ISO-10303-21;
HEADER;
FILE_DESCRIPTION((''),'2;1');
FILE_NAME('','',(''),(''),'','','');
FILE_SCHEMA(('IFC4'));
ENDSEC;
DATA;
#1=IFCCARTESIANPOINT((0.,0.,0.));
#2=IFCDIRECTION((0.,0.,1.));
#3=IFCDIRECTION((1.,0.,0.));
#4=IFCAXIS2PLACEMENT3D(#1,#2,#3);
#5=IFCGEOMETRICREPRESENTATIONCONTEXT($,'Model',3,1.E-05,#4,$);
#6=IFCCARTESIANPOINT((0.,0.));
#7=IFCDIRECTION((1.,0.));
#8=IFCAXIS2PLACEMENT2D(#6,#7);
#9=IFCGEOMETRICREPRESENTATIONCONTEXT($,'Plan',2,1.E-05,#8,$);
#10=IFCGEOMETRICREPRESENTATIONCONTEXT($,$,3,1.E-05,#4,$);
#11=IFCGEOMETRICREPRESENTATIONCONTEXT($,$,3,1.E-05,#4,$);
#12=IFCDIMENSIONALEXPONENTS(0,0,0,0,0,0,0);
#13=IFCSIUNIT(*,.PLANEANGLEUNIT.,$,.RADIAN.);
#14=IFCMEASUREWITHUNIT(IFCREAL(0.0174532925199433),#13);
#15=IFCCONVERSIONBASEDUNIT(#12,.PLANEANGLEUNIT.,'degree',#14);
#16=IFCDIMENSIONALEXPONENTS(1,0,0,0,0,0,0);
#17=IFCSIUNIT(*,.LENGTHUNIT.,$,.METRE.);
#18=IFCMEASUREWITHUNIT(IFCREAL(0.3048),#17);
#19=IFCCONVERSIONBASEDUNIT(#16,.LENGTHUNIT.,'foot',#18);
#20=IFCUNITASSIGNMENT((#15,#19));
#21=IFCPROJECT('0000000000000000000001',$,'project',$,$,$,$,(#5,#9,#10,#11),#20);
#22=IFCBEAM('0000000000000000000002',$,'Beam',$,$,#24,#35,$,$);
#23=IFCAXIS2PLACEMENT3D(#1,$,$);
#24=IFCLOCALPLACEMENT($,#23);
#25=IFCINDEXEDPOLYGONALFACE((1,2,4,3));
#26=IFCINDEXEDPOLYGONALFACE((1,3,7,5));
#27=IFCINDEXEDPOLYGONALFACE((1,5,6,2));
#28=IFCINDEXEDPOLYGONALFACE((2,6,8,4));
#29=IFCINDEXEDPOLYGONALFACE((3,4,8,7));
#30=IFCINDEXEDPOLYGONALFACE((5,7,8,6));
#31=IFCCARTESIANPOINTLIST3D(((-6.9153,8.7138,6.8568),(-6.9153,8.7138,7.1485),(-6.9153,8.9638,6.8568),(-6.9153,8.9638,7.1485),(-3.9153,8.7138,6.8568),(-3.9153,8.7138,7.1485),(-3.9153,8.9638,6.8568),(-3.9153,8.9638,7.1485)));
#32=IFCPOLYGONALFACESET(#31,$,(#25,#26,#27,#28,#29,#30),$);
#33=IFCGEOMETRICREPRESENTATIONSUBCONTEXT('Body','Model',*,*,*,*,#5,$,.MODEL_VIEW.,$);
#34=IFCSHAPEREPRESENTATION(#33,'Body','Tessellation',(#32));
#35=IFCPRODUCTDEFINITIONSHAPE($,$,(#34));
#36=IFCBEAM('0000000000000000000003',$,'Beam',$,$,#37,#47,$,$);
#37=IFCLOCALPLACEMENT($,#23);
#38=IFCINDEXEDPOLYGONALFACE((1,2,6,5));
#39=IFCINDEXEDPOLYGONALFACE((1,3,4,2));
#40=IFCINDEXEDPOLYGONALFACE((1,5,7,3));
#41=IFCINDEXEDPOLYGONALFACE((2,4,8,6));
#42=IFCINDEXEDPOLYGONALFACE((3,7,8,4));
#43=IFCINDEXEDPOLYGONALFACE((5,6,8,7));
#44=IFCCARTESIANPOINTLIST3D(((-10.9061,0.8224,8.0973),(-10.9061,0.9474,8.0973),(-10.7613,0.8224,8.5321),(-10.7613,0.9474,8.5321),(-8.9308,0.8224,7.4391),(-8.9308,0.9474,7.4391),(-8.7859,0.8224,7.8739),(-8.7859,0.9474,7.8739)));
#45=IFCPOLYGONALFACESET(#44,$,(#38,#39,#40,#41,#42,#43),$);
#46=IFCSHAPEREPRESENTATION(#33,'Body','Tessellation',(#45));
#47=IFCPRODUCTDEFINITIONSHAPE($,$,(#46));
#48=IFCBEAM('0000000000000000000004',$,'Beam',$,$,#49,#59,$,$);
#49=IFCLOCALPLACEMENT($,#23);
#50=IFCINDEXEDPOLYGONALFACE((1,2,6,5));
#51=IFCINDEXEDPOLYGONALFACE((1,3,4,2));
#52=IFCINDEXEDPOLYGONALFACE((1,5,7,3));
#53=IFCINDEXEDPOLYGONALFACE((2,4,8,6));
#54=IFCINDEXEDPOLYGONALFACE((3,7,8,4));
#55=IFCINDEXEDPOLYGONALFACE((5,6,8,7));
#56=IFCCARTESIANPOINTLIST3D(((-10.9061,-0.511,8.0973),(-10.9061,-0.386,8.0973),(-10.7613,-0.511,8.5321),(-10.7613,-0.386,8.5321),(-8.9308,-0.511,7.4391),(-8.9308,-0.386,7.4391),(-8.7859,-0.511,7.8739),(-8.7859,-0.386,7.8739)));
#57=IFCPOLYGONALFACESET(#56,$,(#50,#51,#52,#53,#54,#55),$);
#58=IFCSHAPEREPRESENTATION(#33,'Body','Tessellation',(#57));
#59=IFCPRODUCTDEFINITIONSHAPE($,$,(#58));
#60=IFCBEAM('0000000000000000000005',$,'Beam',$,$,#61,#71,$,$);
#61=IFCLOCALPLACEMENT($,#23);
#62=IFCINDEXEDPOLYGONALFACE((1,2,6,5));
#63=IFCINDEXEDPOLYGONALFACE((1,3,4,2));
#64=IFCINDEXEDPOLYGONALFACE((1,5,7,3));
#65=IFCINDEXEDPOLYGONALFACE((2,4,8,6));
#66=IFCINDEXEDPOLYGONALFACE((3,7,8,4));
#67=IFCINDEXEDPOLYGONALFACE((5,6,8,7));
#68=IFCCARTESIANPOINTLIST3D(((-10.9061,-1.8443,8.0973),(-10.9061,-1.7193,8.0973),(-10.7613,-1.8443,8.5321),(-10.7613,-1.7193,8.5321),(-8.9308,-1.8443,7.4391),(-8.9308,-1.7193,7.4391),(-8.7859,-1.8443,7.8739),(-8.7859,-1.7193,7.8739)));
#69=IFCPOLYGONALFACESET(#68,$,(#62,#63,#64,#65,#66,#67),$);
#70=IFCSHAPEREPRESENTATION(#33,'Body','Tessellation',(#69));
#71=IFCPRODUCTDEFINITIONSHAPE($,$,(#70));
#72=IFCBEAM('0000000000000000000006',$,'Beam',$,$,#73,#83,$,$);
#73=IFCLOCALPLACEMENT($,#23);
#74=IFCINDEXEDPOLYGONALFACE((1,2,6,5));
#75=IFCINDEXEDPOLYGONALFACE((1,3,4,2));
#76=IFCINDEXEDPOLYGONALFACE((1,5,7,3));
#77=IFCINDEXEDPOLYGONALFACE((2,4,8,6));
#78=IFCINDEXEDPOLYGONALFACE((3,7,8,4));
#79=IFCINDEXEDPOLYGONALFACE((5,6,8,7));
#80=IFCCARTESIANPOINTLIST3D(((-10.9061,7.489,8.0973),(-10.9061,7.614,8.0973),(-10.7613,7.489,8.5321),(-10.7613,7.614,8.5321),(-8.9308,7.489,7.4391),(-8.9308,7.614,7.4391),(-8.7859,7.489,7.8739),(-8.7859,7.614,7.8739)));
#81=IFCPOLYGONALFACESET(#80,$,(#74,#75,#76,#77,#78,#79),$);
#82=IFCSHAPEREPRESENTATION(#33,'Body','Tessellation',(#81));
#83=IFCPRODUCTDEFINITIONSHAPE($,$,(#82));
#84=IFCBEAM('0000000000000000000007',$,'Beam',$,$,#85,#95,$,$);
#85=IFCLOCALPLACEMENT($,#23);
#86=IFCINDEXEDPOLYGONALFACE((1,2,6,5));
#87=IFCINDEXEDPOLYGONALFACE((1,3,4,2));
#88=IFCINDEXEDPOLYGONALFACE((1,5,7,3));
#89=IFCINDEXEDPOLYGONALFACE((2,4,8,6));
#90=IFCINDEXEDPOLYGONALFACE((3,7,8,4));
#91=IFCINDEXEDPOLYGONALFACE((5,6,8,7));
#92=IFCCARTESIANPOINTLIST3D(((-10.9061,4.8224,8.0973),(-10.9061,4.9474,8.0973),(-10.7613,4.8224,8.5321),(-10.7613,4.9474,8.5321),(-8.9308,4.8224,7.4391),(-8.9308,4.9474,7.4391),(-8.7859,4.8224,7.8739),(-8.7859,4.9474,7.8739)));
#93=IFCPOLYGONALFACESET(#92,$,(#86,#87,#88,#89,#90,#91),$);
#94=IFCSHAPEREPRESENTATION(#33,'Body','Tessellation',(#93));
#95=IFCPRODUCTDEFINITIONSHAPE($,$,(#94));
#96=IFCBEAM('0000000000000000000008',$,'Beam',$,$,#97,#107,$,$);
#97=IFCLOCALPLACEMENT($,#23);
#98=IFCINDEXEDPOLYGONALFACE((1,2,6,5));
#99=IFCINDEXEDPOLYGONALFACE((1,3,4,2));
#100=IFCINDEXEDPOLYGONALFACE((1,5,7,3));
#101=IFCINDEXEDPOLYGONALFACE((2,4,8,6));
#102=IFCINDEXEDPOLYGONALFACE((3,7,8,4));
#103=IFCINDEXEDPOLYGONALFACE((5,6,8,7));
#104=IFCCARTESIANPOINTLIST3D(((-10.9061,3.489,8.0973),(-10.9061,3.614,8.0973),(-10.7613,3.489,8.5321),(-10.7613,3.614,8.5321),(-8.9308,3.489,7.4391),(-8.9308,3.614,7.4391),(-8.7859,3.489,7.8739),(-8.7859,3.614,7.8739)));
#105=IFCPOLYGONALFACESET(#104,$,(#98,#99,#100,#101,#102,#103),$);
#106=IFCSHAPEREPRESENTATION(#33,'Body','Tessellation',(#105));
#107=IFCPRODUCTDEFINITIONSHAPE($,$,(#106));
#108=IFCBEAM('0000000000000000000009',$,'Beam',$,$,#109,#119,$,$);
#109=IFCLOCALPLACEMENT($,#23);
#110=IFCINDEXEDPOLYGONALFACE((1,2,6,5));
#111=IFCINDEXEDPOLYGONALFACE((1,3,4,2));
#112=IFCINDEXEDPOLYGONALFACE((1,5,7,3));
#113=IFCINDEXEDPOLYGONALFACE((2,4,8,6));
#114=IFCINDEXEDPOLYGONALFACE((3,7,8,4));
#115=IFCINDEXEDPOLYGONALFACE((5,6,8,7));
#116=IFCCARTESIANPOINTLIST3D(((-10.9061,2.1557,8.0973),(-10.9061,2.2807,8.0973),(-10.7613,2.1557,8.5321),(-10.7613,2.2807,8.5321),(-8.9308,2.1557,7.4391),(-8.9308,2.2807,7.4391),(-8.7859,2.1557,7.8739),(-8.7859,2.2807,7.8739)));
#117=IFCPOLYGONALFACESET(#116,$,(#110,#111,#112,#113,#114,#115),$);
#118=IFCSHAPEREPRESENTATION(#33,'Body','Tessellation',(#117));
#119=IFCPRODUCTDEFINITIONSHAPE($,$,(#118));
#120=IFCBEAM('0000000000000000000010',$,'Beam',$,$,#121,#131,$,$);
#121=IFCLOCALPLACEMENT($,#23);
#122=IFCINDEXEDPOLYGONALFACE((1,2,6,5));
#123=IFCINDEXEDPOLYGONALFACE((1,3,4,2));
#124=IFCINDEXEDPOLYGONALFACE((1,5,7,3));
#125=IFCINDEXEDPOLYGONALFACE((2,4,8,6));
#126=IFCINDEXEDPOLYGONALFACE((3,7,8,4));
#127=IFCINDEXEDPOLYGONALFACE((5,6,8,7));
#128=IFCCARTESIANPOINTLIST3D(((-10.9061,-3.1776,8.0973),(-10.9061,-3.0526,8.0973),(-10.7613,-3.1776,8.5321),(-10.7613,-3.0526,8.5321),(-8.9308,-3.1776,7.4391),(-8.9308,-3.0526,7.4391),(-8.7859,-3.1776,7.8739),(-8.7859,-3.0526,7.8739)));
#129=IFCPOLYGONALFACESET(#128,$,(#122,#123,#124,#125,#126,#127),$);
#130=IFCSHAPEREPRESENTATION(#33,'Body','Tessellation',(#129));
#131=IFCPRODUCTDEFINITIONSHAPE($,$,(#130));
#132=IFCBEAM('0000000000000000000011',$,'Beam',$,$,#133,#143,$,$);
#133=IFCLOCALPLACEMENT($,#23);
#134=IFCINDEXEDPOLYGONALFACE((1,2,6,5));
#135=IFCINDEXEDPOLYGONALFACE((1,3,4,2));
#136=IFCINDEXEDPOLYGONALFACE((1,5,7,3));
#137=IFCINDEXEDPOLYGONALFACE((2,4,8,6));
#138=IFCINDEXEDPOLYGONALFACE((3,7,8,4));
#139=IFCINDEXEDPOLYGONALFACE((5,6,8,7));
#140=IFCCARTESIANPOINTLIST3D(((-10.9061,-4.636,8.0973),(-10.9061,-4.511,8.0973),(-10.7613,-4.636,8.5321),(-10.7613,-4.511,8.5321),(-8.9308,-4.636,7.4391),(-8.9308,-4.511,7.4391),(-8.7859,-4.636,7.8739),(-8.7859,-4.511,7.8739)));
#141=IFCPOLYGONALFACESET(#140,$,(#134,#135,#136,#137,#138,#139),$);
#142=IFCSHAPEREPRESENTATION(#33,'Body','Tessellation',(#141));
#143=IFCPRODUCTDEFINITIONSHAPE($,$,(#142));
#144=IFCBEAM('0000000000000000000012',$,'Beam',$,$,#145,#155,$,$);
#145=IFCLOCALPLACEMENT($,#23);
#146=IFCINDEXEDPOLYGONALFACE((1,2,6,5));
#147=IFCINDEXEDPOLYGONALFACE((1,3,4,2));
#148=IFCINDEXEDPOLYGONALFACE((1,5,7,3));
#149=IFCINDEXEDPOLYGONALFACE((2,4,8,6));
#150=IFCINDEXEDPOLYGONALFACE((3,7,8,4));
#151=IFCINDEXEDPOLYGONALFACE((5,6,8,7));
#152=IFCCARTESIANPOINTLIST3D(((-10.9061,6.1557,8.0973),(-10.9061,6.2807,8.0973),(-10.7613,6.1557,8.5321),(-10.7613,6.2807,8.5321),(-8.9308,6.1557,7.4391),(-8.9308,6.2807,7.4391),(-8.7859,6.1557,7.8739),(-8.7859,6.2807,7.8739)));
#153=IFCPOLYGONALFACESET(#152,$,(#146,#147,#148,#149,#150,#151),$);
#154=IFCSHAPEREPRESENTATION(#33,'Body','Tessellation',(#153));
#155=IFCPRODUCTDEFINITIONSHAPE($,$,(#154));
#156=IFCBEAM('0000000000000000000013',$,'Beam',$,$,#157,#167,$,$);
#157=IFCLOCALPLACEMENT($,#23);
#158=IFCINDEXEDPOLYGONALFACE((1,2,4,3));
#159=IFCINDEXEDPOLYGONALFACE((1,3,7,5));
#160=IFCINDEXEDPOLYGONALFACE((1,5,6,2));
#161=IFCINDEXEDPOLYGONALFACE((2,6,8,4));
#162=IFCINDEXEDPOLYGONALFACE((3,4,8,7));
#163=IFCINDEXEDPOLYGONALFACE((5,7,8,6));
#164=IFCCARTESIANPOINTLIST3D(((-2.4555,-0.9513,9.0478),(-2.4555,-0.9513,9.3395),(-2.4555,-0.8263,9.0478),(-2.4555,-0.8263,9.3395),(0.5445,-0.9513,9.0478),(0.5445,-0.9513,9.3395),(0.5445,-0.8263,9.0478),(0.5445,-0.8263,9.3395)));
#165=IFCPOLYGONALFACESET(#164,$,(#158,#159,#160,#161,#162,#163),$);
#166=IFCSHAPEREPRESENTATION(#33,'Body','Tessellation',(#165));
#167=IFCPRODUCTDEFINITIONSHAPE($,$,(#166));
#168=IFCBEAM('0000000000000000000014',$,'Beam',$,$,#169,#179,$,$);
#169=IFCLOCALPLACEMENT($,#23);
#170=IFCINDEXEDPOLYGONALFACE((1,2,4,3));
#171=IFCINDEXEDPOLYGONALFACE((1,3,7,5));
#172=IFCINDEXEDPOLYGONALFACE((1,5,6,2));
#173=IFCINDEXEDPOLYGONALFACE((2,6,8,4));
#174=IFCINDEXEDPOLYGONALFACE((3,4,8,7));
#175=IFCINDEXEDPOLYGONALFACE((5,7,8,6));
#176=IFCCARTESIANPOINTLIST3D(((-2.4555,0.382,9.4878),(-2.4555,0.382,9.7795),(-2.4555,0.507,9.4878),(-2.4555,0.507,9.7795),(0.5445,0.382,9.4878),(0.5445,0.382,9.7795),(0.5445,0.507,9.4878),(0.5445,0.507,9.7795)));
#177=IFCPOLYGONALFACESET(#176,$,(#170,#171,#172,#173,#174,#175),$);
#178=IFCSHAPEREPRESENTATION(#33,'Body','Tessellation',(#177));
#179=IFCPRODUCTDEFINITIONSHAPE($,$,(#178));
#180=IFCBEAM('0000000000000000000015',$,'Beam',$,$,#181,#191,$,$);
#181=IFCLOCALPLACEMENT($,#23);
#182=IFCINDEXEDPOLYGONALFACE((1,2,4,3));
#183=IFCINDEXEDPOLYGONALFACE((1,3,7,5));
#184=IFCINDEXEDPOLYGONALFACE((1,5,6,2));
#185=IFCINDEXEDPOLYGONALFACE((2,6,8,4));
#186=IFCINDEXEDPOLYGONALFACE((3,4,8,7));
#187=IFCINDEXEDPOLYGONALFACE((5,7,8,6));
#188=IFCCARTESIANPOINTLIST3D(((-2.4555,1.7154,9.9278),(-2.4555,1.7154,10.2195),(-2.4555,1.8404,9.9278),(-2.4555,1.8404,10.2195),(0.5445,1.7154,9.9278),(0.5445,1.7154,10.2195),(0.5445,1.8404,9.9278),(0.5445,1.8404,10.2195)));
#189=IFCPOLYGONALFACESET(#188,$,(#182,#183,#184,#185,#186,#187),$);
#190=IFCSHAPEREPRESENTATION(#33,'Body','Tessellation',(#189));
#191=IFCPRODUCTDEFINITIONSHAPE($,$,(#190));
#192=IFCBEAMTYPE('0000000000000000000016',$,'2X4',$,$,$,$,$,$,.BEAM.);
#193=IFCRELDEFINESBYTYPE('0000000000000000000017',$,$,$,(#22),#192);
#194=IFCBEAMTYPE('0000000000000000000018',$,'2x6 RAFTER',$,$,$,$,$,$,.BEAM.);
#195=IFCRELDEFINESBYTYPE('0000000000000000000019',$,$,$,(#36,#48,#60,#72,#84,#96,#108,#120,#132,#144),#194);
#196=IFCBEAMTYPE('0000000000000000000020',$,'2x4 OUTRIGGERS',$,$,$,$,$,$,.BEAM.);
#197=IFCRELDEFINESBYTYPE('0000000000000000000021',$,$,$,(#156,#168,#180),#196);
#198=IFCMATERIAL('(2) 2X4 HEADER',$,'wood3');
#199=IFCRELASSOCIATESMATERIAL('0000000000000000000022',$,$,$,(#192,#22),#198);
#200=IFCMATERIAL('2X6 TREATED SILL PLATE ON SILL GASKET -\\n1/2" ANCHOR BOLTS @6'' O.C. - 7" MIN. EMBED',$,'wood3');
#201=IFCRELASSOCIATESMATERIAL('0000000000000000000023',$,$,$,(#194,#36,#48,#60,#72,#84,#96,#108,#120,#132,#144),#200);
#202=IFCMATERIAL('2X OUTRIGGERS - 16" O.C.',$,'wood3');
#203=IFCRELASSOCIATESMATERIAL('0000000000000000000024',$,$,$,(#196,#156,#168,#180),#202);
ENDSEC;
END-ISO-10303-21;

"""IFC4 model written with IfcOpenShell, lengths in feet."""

from ifc_helpers import new_model, entity, si_unit, converted_unit, frame, origin_with_axes, origin_2d_with_axis, place, context, subcontext, project, rectangle, extrude, material, material_profile, profile_set, profile_usage, type_object, element, save


model = new_model("IFC4")

# Units and contexts
model_context = context("Model", 3, precision=1e-05, world=origin_with_axes())
plan_context = context("Plan", 2, precision=1e-05, world=origin_2d_with_axis())
context_of_model_1 = context(None, 3, precision=1e-05, world=origin_with_axes())
context_of_model_2 = context(None, 3, precision=1e-05, world=origin_with_axes())
body_context = subcontext(model_context, "Body", "Model", "MODEL_VIEW")
ifc_project = project(units=[converted_unit("PLANEANGLEUNIT", "degree", entity("IfcReal", 0.0174532925199433), si_unit("PLANEANGLEUNIT", "RADIAN"), dimensions=[0, 0, 0, 0, 0, 0, 0]), converted_unit("LENGTHUNIT", "foot", entity("IfcReal", 0.3048), si_unit("LENGTHUNIT", "METRE"), dimensions=[1, 0, 0, 0, 0, 0, 0])], contexts=[model_context, plan_context, context_of_model_1, context_of_model_2])

# Beams
ifc_material_1 = material(Name="(2) 2X4 HEADER", Category="wood3")
ifc_material_profile_1 = material_profile(ifc_material_1, rectangle(XDim=0.25, YDim=0.2917))
ifc_profile_set_1 = profile_set([ifc_material_profile_1])
ifc_profile_usage_1 = profile_usage(ifc_profile_set_1, cardinal=5)
beam_type_1 = type_object("IfcBeamType", Name="2X4", PredefinedType="BEAM", material=ifc_profile_set_1)
beam_1_placement = place(None, frame((-6.9153, 8.8388, 7.0026), z_axis=(1.0, 0.0, 0.0), x_axis=(0.0, 1.0, 0.0)))
element("IfcBeam", 1, at=beam_1_placement, type_object=beam_type_1, material=ifc_profile_usage_1, Name="Beam", context=body_context, shape_type="SweptSolid", body=[
    extrude(rectangle(XDim=0.25, YDim=0.2917), origin_with_axes(), (0.0, 0.0, 1.0), 3.0),
])
ifc_material_2 = material(Name="2X6 TREATED SILL PLATE ON SILL GASKET -\\n1/2\" ANCHOR BOLTS @6' O.C. - 7\" MIN. EMBED", Category="wood3")
ifc_material_profile_2 = material_profile(ifc_material_2, rectangle(XDim=0.125, YDim=0.4583))
ifc_profile_set_2 = profile_set([ifc_material_profile_2])
ifc_profile_usage_2 = profile_usage(ifc_profile_set_2, cardinal=5)
beam_type_2 = type_object("IfcBeamType", Name="2x6 RAFTER", PredefinedType="BEAM", material=ifc_profile_set_2)
beam_2_placement = place(None, frame((-8.8584, 0.8849, 7.6565), z_axis=(-0.948711, 0.0, 0.316146), x_axis=(0.0, 1.0, 0.0)))
element("IfcBeam", 2, at=beam_2_placement, type_object=beam_type_2, material=ifc_profile_usage_2, Name="Beam", context=body_context, shape_type="SweptSolid", body=[
    extrude(rectangle(XDim=0.125, YDim=0.4583), origin_with_axes(), (0.0, 0.0, 1.0), 2.0821),
])
ifc_profile_usage_3 = profile_usage(ifc_profile_set_2, cardinal=5)
beam_3_placement = place(None, frame((-8.8584, -0.4485, 7.6565), z_axis=(-0.948711, 0.0, 0.316146), x_axis=(0.0, 1.0, 0.0)))
element("IfcBeam", 3, at=beam_3_placement, type_object=beam_type_2, material=ifc_profile_usage_3, Name="Beam", context=body_context, shape_type="SweptSolid", body=[
    extrude(rectangle(XDim=0.125, YDim=0.4583), origin_with_axes(), (0.0, 0.0, 1.0), 2.0821),
])
ifc_profile_usage_4 = profile_usage(ifc_profile_set_2, cardinal=5)
beam_4_placement = place(None, frame((-8.8584, -1.7818, 7.6565), z_axis=(-0.948711, 0.0, 0.316146), x_axis=(0.0, 1.0, 0.0)))
element("IfcBeam", 4, at=beam_4_placement, type_object=beam_type_2, material=ifc_profile_usage_4, Name="Beam", context=body_context, shape_type="SweptSolid", body=[
    extrude(rectangle(XDim=0.125, YDim=0.4583), origin_with_axes(), (0.0, 0.0, 1.0), 2.0821),
])
ifc_profile_usage_5 = profile_usage(ifc_profile_set_2, cardinal=5)
beam_5_placement = place(None, frame((-8.8584, 7.5515, 7.6565), z_axis=(-0.948711, 0.0, 0.316146), x_axis=(0.0, 1.0, 0.0)))
element("IfcBeam", 5, at=beam_5_placement, type_object=beam_type_2, material=ifc_profile_usage_5, Name="Beam", context=body_context, shape_type="SweptSolid", body=[
    extrude(rectangle(XDim=0.125, YDim=0.4583), origin_with_axes(), (0.0, 0.0, 1.0), 2.0821),
])
ifc_profile_usage_6 = profile_usage(ifc_profile_set_2, cardinal=5)
beam_6_placement = place(None, frame((-8.8584, 4.8849, 7.6565), z_axis=(-0.948711, 0.0, 0.316146), x_axis=(0.0, 1.0, 0.0)))
element("IfcBeam", 6, at=beam_6_placement, type_object=beam_type_2, material=ifc_profile_usage_6, Name="Beam", context=body_context, shape_type="SweptSolid", body=[
    extrude(rectangle(XDim=0.125, YDim=0.4583), origin_with_axes(), (0.0, 0.0, 1.0), 2.0821),
])
ifc_profile_usage_7 = profile_usage(ifc_profile_set_2, cardinal=5)
beam_7_placement = place(None, frame((-8.8584, 3.5515, 7.6565), z_axis=(-0.948711, 0.0, 0.316146), x_axis=(0.0, 1.0, 0.0)))
element("IfcBeam", 7, at=beam_7_placement, type_object=beam_type_2, material=ifc_profile_usage_7, Name="Beam", context=body_context, shape_type="SweptSolid", body=[
    extrude(rectangle(XDim=0.125, YDim=0.4583), origin_with_axes(), (0.0, 0.0, 1.0), 2.0821),
])
ifc_profile_usage_8 = profile_usage(ifc_profile_set_2, cardinal=5)
beam_8_placement = place(None, frame((-8.8584, 2.2182, 7.6565), z_axis=(-0.948711, 0.0, 0.316146), x_axis=(0.0, 1.0, 0.0)))
element("IfcBeam", 8, at=beam_8_placement, type_object=beam_type_2, material=ifc_profile_usage_8, Name="Beam", context=body_context, shape_type="SweptSolid", body=[
    extrude(rectangle(XDim=0.125, YDim=0.4583), origin_with_axes(), (0.0, 0.0, 1.0), 2.0821),
])
ifc_profile_usage_9 = profile_usage(ifc_profile_set_2, cardinal=5)
beam_9_placement = place(None, frame((-8.8584, -3.1151, 7.6565), z_axis=(-0.948711, 0.0, 0.316146), x_axis=(0.0, 1.0, 0.0)))
element("IfcBeam", 9, at=beam_9_placement, type_object=beam_type_2, material=ifc_profile_usage_9, Name="Beam", context=body_context, shape_type="SweptSolid", body=[
    extrude(rectangle(XDim=0.125, YDim=0.4583), origin_with_axes(), (0.0, 0.0, 1.0), 2.0821),
])
ifc_profile_usage_10 = profile_usage(ifc_profile_set_2, cardinal=5)
beam_10_placement = place(None, frame((-8.8584, -4.5735, 7.6565), z_axis=(-0.948711, 0.0, 0.316146), x_axis=(0.0, 1.0, 0.0)))
element("IfcBeam", 10, at=beam_10_placement, type_object=beam_type_2, material=ifc_profile_usage_10, Name="Beam", context=body_context, shape_type="SweptSolid", body=[
    extrude(rectangle(XDim=0.125, YDim=0.4583), origin_with_axes(), (0.0, 0.0, 1.0), 2.0821),
])
ifc_profile_usage_11 = profile_usage(ifc_profile_set_2, cardinal=5)
beam_11_placement = place(None, frame((-8.8584, 6.2182, 7.6565), z_axis=(-0.948711, 0.0, 0.316146), x_axis=(0.0, 1.0, 0.0)))
element("IfcBeam", 11, at=beam_11_placement, type_object=beam_type_2, material=ifc_profile_usage_11, Name="Beam", context=body_context, shape_type="SweptSolid", body=[
    extrude(rectangle(XDim=0.125, YDim=0.4583), origin_with_axes(), (0.0, 0.0, 1.0), 2.0821),
])
ifc_material_3 = material(Name="2X OUTRIGGERS - 16\" O.C.", Category="wood3")
ifc_material_profile_3 = material_profile(ifc_material_3, rectangle(XDim=0.125, YDim=0.2917))
ifc_profile_set_3 = profile_set([ifc_material_profile_3])
ifc_profile_usage_12 = profile_usage(ifc_profile_set_3, cardinal=5)
beam_type_3 = type_object("IfcBeamType", Name="2x4 OUTRIGGERS", PredefinedType="BEAM", material=ifc_profile_set_3)
beam_12_placement = place(None, frame((-2.4555, -0.8888, 9.1937), z_axis=(1.0, 0.0, 0.0), x_axis=(0.0, 1.0, 0.0)))
element("IfcBeam", 12, at=beam_12_placement, type_object=beam_type_3, material=ifc_profile_usage_12, Name="Beam", context=body_context, shape_type="SweptSolid", body=[
    extrude(rectangle(XDim=0.125, YDim=0.2917), origin_with_axes(), (0.0, 0.0, 1.0), 3.0),
])
ifc_profile_usage_13 = profile_usage(ifc_profile_set_3, cardinal=5)
beam_13_placement = place(None, frame((-2.4555, 0.4445, 9.6337), z_axis=(1.0, 0.0, 0.0), x_axis=(0.0, 1.0, 0.0)))
element("IfcBeam", 13, at=beam_13_placement, type_object=beam_type_3, material=ifc_profile_usage_13, Name="Beam", context=body_context, shape_type="SweptSolid", body=[
    extrude(rectangle(XDim=0.125, YDim=0.2917), origin_with_axes(), (0.0, 0.0, 1.0), 3.0),
])
ifc_profile_usage_14 = profile_usage(ifc_profile_set_3, cardinal=5)
beam_14_placement = place(None, frame((-2.4555, 1.7779, 10.0737), z_axis=(1.0, 0.0, 0.0), x_axis=(0.0, 1.0, 0.0)))
element("IfcBeam", 14, at=beam_14_placement, type_object=beam_type_3, material=ifc_profile_usage_14, Name="Beam", context=body_context, shape_type="SweptSolid", body=[
    extrude(rectangle(XDim=0.125, YDim=0.2917), origin_with_axes(), (0.0, 0.0, 1.0), 3.0),
])

save(model, "model.ifc")
